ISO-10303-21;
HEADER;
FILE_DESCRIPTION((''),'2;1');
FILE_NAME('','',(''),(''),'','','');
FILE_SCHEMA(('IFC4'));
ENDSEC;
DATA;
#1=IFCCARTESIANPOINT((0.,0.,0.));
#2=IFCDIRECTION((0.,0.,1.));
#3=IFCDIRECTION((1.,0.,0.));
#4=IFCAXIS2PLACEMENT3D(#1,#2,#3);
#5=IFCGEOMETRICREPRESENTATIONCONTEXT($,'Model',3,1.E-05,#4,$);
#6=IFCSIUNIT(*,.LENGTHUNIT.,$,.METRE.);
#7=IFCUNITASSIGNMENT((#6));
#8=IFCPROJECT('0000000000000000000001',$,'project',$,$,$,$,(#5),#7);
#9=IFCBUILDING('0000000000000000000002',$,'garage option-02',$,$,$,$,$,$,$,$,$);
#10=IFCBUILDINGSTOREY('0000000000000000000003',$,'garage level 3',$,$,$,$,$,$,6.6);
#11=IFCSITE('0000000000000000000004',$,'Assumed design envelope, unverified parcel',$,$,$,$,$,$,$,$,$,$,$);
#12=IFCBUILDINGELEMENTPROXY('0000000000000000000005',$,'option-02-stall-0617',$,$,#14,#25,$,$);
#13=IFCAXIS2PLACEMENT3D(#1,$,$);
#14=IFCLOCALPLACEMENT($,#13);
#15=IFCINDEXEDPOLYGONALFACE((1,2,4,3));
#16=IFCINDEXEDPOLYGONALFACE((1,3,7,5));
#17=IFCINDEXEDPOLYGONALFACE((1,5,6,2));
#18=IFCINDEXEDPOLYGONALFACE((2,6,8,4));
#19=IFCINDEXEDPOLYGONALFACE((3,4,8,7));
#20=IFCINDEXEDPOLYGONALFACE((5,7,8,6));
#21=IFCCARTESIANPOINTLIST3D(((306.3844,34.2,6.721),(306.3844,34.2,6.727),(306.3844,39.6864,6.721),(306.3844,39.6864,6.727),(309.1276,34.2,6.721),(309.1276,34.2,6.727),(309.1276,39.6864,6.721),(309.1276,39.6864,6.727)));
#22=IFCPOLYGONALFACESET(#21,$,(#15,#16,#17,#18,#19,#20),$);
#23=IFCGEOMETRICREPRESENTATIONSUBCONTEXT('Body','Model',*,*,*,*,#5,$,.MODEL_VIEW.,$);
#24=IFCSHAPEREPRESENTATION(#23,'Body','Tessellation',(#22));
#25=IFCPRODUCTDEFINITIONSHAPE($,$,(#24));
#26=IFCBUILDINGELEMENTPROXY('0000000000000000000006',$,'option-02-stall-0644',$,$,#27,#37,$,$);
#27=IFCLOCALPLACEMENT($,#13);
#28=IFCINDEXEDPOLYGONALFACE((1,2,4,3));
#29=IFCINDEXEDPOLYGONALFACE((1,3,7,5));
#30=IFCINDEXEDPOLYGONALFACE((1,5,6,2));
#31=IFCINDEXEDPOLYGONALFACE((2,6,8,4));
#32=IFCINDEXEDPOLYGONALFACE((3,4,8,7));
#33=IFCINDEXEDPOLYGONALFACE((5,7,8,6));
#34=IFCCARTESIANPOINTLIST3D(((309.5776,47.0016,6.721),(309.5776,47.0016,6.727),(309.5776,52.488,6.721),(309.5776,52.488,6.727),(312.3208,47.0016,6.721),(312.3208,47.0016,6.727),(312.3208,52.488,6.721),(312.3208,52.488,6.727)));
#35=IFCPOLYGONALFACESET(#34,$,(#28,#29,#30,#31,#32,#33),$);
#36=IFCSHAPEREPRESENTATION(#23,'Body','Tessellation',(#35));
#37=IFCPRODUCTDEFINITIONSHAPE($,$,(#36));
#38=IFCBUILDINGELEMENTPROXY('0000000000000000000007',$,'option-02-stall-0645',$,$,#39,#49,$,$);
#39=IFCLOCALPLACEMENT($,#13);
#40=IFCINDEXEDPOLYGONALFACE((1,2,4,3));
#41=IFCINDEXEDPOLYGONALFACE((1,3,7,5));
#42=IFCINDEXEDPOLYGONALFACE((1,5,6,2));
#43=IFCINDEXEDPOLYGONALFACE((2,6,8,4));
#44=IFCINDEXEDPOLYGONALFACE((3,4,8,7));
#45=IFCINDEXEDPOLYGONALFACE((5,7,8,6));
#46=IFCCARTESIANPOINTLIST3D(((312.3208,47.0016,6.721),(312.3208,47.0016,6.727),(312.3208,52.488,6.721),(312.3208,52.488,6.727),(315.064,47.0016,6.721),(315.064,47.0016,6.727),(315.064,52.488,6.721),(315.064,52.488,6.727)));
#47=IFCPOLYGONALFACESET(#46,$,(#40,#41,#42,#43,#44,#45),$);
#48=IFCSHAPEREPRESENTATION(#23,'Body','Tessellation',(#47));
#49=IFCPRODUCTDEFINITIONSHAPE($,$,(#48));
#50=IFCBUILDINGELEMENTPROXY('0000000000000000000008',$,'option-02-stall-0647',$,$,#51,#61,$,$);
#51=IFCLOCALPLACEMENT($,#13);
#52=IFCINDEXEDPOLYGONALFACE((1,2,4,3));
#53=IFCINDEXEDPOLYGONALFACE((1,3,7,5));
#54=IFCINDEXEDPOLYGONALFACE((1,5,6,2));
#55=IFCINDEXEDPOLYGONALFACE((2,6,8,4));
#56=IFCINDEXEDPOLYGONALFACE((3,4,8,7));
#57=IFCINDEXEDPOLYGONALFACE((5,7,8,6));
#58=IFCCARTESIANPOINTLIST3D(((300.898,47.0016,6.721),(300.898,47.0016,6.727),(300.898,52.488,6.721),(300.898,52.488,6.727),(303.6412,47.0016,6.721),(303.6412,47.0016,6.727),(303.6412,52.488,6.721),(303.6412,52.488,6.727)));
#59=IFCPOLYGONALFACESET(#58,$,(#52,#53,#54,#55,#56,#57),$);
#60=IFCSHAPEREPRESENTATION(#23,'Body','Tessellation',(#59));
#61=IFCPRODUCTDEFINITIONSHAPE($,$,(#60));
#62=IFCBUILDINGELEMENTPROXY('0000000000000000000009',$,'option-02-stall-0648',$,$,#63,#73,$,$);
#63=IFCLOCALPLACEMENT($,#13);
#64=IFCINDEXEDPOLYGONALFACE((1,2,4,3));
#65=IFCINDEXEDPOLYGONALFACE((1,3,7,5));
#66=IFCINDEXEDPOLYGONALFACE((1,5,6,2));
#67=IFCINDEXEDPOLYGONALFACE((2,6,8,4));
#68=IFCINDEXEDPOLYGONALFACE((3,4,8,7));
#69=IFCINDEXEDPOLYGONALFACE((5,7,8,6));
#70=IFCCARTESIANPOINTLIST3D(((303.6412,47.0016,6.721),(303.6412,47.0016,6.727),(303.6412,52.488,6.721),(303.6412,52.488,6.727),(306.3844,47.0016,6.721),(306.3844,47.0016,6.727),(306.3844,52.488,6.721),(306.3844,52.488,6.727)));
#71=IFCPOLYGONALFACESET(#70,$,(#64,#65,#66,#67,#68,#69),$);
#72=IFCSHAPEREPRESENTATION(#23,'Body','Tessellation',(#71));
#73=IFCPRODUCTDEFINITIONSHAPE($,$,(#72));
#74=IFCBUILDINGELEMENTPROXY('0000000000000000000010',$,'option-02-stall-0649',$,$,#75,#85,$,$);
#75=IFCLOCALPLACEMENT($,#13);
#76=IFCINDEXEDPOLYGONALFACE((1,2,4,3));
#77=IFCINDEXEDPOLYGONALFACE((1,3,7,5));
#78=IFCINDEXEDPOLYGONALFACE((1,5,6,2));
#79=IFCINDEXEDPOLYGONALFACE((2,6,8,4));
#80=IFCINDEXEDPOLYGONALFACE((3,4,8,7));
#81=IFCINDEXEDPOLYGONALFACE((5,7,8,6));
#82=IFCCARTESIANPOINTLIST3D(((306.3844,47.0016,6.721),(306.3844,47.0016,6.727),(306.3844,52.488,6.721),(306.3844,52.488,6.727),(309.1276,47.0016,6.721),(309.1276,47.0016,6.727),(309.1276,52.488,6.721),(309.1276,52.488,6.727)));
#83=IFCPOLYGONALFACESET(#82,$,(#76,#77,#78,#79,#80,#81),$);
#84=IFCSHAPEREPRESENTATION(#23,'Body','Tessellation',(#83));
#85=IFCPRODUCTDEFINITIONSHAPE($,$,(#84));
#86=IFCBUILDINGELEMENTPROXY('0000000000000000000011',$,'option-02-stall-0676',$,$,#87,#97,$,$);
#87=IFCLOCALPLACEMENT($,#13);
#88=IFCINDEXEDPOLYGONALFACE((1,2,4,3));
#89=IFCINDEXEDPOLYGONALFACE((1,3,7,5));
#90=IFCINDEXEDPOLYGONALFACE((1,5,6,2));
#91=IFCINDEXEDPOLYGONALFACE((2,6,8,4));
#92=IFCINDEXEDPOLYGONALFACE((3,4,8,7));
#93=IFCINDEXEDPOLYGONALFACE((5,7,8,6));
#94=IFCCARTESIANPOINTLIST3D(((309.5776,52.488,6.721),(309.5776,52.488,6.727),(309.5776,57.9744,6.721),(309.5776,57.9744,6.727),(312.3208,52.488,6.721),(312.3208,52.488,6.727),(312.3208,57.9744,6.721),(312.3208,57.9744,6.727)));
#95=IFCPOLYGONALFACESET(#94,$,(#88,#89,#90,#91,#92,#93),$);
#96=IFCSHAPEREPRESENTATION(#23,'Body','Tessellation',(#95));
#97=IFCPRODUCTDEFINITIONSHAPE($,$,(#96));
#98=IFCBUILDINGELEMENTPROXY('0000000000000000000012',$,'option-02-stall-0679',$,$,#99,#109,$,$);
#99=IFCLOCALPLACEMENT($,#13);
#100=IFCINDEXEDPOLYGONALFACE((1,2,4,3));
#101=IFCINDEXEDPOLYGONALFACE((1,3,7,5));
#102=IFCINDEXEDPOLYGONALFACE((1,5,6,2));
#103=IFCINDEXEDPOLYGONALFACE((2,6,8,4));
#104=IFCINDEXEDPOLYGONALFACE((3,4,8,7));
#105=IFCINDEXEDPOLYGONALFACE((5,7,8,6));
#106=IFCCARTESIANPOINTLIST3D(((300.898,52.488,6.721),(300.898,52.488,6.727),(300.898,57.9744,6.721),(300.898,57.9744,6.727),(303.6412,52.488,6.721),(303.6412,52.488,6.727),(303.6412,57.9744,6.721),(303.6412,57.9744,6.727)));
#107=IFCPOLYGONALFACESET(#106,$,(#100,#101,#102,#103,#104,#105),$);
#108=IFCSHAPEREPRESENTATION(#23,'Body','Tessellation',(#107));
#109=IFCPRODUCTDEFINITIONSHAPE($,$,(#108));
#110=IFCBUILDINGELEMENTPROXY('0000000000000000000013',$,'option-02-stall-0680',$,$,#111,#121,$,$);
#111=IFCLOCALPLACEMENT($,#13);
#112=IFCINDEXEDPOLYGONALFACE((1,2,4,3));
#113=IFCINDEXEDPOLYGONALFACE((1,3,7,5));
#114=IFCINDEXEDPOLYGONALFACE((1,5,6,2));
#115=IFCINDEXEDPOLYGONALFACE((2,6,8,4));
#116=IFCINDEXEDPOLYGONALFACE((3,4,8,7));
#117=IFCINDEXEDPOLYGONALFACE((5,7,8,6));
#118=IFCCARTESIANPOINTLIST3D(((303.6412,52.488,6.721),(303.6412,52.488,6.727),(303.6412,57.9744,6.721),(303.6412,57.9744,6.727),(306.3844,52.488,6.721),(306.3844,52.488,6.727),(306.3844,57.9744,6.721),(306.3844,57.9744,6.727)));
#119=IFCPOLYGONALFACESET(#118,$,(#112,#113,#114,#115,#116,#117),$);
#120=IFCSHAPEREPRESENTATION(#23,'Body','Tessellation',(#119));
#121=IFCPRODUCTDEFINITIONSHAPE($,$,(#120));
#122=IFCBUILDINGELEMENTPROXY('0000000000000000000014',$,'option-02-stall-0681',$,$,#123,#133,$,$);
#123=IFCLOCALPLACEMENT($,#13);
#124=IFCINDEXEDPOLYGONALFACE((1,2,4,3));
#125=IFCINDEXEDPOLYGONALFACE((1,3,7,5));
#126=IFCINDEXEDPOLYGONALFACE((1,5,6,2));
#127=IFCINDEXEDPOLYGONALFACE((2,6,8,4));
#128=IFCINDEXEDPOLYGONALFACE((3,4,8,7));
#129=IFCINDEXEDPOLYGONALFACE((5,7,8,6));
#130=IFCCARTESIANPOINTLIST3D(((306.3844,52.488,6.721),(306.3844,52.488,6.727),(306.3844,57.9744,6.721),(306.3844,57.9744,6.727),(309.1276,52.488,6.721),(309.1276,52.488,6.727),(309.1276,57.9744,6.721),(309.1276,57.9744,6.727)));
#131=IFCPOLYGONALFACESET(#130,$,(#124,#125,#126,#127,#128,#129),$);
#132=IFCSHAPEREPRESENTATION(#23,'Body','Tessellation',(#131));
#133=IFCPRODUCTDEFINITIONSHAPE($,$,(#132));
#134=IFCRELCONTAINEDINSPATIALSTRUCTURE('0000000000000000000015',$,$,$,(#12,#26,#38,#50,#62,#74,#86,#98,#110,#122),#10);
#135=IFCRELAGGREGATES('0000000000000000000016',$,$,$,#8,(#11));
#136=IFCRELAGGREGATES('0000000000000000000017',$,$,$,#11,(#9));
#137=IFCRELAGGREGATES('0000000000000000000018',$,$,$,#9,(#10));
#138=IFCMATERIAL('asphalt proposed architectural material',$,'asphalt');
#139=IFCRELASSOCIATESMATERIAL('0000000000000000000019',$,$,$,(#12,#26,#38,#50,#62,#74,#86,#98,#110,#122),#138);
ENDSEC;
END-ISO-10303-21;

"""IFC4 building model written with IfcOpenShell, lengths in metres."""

from ifc_helpers import new_model, si_unit, frame, origin_with_axes, place, context, subcontext, project, spatial, rectangle, extrude, material, element, save


model = new_model("IFC4")

# Units and contexts
model_context = context("Model", 3, precision=1e-05, world=origin_with_axes())
body_context = subcontext(model_context, "Body", "Model", "MODEL_VIEW")
ifc_project = project(units=[si_unit("LENGTHUNIT", "METRE")], contexts=[model_context])

# Site, building, storey
site = spatial("IfcSite", under=ifc_project, Name="Assumed design envelope, unverified parcel")
building = spatial("IfcBuilding", under=site, Name="garage option-02")
storey = spatial("IfcBuildingStorey", under=building, Name="garage level 3", Elevation=6.6)

# Building element proxies
ifc_material_1 = material(Name="asphalt proposed architectural material", Category="asphalt")
for number, where, z_axis, x_axis, name in (
    (1, (307.756, 36.9432, 6.721), (0.0, 0.0, 1.0), (1.0, 0.0, 0.0), "option-02-stall-0617"),
    (2, (310.9492, 49.7448, 6.721), (0.0, 0.0, 1.0), (1.0, 0.0, 0.0), "option-02-stall-0644"),
    (3, (313.6924, 49.7448, 6.721), (0.0, 0.0, 1.0), (1.0, 0.0, 0.0), "option-02-stall-0645"),
    (4, (302.2696, 49.7448, 6.721), (0.0, 0.0, 1.0), (1.0, 0.0, 0.0), "option-02-stall-0647"),
    (5, (305.0128, 49.7448, 6.721), (0.0, 0.0, 1.0), (1.0, 0.0, 0.0), "option-02-stall-0648"),
    (6, (307.756, 49.7448, 6.721), (0.0, 0.0, 1.0), (1.0, 0.0, 0.0), "option-02-stall-0649"),
):
    element("IfcBuildingElementProxy", number, at=place(None, frame(where, z_axis=z_axis, x_axis=x_axis)), inside=storey, material=ifc_material_1, Name=name, context=body_context, shape_type="SweptSolid", body=[
        extrude(rectangle(XDim=2.7432, YDim=5.4864), origin_with_axes(), (0.0, 0.0, 1.0), 0.006),
    ])
for number, where, z_axis, x_axis, name in (
    (7, (310.9492, 55.2312, 6.721), (0.0, 0.0, 1.0), (1.0, 0.0, 0.0), "option-02-stall-0676"),
    (8, (302.2696, 55.2312, 6.721), (0.0, 0.0, 1.0), (1.0, 0.0, 0.0), "option-02-stall-0679"),
    (9, (305.0128, 55.2312, 6.721), (0.0, 0.0, 1.0), (1.0, 0.0, 0.0), "option-02-stall-0680"),
    (10, (307.756, 55.2312, 6.721), (0.0, 0.0, 1.0), (1.0, 0.0, 0.0), "option-02-stall-0681"),
):
    element("IfcBuildingElementProxy", number, at=place(None, frame(where, z_axis=z_axis, x_axis=x_axis)), inside=storey, material=ifc_material_1, Name=name, context=body_context, shape_type="SweptSolid", body=[
        extrude(rectangle(XDim=2.7432, YDim=5.4864), origin_with_axes(), (0.0, 0.0, 1.0), 0.006),
    ])

save(model, "model.ifc")
